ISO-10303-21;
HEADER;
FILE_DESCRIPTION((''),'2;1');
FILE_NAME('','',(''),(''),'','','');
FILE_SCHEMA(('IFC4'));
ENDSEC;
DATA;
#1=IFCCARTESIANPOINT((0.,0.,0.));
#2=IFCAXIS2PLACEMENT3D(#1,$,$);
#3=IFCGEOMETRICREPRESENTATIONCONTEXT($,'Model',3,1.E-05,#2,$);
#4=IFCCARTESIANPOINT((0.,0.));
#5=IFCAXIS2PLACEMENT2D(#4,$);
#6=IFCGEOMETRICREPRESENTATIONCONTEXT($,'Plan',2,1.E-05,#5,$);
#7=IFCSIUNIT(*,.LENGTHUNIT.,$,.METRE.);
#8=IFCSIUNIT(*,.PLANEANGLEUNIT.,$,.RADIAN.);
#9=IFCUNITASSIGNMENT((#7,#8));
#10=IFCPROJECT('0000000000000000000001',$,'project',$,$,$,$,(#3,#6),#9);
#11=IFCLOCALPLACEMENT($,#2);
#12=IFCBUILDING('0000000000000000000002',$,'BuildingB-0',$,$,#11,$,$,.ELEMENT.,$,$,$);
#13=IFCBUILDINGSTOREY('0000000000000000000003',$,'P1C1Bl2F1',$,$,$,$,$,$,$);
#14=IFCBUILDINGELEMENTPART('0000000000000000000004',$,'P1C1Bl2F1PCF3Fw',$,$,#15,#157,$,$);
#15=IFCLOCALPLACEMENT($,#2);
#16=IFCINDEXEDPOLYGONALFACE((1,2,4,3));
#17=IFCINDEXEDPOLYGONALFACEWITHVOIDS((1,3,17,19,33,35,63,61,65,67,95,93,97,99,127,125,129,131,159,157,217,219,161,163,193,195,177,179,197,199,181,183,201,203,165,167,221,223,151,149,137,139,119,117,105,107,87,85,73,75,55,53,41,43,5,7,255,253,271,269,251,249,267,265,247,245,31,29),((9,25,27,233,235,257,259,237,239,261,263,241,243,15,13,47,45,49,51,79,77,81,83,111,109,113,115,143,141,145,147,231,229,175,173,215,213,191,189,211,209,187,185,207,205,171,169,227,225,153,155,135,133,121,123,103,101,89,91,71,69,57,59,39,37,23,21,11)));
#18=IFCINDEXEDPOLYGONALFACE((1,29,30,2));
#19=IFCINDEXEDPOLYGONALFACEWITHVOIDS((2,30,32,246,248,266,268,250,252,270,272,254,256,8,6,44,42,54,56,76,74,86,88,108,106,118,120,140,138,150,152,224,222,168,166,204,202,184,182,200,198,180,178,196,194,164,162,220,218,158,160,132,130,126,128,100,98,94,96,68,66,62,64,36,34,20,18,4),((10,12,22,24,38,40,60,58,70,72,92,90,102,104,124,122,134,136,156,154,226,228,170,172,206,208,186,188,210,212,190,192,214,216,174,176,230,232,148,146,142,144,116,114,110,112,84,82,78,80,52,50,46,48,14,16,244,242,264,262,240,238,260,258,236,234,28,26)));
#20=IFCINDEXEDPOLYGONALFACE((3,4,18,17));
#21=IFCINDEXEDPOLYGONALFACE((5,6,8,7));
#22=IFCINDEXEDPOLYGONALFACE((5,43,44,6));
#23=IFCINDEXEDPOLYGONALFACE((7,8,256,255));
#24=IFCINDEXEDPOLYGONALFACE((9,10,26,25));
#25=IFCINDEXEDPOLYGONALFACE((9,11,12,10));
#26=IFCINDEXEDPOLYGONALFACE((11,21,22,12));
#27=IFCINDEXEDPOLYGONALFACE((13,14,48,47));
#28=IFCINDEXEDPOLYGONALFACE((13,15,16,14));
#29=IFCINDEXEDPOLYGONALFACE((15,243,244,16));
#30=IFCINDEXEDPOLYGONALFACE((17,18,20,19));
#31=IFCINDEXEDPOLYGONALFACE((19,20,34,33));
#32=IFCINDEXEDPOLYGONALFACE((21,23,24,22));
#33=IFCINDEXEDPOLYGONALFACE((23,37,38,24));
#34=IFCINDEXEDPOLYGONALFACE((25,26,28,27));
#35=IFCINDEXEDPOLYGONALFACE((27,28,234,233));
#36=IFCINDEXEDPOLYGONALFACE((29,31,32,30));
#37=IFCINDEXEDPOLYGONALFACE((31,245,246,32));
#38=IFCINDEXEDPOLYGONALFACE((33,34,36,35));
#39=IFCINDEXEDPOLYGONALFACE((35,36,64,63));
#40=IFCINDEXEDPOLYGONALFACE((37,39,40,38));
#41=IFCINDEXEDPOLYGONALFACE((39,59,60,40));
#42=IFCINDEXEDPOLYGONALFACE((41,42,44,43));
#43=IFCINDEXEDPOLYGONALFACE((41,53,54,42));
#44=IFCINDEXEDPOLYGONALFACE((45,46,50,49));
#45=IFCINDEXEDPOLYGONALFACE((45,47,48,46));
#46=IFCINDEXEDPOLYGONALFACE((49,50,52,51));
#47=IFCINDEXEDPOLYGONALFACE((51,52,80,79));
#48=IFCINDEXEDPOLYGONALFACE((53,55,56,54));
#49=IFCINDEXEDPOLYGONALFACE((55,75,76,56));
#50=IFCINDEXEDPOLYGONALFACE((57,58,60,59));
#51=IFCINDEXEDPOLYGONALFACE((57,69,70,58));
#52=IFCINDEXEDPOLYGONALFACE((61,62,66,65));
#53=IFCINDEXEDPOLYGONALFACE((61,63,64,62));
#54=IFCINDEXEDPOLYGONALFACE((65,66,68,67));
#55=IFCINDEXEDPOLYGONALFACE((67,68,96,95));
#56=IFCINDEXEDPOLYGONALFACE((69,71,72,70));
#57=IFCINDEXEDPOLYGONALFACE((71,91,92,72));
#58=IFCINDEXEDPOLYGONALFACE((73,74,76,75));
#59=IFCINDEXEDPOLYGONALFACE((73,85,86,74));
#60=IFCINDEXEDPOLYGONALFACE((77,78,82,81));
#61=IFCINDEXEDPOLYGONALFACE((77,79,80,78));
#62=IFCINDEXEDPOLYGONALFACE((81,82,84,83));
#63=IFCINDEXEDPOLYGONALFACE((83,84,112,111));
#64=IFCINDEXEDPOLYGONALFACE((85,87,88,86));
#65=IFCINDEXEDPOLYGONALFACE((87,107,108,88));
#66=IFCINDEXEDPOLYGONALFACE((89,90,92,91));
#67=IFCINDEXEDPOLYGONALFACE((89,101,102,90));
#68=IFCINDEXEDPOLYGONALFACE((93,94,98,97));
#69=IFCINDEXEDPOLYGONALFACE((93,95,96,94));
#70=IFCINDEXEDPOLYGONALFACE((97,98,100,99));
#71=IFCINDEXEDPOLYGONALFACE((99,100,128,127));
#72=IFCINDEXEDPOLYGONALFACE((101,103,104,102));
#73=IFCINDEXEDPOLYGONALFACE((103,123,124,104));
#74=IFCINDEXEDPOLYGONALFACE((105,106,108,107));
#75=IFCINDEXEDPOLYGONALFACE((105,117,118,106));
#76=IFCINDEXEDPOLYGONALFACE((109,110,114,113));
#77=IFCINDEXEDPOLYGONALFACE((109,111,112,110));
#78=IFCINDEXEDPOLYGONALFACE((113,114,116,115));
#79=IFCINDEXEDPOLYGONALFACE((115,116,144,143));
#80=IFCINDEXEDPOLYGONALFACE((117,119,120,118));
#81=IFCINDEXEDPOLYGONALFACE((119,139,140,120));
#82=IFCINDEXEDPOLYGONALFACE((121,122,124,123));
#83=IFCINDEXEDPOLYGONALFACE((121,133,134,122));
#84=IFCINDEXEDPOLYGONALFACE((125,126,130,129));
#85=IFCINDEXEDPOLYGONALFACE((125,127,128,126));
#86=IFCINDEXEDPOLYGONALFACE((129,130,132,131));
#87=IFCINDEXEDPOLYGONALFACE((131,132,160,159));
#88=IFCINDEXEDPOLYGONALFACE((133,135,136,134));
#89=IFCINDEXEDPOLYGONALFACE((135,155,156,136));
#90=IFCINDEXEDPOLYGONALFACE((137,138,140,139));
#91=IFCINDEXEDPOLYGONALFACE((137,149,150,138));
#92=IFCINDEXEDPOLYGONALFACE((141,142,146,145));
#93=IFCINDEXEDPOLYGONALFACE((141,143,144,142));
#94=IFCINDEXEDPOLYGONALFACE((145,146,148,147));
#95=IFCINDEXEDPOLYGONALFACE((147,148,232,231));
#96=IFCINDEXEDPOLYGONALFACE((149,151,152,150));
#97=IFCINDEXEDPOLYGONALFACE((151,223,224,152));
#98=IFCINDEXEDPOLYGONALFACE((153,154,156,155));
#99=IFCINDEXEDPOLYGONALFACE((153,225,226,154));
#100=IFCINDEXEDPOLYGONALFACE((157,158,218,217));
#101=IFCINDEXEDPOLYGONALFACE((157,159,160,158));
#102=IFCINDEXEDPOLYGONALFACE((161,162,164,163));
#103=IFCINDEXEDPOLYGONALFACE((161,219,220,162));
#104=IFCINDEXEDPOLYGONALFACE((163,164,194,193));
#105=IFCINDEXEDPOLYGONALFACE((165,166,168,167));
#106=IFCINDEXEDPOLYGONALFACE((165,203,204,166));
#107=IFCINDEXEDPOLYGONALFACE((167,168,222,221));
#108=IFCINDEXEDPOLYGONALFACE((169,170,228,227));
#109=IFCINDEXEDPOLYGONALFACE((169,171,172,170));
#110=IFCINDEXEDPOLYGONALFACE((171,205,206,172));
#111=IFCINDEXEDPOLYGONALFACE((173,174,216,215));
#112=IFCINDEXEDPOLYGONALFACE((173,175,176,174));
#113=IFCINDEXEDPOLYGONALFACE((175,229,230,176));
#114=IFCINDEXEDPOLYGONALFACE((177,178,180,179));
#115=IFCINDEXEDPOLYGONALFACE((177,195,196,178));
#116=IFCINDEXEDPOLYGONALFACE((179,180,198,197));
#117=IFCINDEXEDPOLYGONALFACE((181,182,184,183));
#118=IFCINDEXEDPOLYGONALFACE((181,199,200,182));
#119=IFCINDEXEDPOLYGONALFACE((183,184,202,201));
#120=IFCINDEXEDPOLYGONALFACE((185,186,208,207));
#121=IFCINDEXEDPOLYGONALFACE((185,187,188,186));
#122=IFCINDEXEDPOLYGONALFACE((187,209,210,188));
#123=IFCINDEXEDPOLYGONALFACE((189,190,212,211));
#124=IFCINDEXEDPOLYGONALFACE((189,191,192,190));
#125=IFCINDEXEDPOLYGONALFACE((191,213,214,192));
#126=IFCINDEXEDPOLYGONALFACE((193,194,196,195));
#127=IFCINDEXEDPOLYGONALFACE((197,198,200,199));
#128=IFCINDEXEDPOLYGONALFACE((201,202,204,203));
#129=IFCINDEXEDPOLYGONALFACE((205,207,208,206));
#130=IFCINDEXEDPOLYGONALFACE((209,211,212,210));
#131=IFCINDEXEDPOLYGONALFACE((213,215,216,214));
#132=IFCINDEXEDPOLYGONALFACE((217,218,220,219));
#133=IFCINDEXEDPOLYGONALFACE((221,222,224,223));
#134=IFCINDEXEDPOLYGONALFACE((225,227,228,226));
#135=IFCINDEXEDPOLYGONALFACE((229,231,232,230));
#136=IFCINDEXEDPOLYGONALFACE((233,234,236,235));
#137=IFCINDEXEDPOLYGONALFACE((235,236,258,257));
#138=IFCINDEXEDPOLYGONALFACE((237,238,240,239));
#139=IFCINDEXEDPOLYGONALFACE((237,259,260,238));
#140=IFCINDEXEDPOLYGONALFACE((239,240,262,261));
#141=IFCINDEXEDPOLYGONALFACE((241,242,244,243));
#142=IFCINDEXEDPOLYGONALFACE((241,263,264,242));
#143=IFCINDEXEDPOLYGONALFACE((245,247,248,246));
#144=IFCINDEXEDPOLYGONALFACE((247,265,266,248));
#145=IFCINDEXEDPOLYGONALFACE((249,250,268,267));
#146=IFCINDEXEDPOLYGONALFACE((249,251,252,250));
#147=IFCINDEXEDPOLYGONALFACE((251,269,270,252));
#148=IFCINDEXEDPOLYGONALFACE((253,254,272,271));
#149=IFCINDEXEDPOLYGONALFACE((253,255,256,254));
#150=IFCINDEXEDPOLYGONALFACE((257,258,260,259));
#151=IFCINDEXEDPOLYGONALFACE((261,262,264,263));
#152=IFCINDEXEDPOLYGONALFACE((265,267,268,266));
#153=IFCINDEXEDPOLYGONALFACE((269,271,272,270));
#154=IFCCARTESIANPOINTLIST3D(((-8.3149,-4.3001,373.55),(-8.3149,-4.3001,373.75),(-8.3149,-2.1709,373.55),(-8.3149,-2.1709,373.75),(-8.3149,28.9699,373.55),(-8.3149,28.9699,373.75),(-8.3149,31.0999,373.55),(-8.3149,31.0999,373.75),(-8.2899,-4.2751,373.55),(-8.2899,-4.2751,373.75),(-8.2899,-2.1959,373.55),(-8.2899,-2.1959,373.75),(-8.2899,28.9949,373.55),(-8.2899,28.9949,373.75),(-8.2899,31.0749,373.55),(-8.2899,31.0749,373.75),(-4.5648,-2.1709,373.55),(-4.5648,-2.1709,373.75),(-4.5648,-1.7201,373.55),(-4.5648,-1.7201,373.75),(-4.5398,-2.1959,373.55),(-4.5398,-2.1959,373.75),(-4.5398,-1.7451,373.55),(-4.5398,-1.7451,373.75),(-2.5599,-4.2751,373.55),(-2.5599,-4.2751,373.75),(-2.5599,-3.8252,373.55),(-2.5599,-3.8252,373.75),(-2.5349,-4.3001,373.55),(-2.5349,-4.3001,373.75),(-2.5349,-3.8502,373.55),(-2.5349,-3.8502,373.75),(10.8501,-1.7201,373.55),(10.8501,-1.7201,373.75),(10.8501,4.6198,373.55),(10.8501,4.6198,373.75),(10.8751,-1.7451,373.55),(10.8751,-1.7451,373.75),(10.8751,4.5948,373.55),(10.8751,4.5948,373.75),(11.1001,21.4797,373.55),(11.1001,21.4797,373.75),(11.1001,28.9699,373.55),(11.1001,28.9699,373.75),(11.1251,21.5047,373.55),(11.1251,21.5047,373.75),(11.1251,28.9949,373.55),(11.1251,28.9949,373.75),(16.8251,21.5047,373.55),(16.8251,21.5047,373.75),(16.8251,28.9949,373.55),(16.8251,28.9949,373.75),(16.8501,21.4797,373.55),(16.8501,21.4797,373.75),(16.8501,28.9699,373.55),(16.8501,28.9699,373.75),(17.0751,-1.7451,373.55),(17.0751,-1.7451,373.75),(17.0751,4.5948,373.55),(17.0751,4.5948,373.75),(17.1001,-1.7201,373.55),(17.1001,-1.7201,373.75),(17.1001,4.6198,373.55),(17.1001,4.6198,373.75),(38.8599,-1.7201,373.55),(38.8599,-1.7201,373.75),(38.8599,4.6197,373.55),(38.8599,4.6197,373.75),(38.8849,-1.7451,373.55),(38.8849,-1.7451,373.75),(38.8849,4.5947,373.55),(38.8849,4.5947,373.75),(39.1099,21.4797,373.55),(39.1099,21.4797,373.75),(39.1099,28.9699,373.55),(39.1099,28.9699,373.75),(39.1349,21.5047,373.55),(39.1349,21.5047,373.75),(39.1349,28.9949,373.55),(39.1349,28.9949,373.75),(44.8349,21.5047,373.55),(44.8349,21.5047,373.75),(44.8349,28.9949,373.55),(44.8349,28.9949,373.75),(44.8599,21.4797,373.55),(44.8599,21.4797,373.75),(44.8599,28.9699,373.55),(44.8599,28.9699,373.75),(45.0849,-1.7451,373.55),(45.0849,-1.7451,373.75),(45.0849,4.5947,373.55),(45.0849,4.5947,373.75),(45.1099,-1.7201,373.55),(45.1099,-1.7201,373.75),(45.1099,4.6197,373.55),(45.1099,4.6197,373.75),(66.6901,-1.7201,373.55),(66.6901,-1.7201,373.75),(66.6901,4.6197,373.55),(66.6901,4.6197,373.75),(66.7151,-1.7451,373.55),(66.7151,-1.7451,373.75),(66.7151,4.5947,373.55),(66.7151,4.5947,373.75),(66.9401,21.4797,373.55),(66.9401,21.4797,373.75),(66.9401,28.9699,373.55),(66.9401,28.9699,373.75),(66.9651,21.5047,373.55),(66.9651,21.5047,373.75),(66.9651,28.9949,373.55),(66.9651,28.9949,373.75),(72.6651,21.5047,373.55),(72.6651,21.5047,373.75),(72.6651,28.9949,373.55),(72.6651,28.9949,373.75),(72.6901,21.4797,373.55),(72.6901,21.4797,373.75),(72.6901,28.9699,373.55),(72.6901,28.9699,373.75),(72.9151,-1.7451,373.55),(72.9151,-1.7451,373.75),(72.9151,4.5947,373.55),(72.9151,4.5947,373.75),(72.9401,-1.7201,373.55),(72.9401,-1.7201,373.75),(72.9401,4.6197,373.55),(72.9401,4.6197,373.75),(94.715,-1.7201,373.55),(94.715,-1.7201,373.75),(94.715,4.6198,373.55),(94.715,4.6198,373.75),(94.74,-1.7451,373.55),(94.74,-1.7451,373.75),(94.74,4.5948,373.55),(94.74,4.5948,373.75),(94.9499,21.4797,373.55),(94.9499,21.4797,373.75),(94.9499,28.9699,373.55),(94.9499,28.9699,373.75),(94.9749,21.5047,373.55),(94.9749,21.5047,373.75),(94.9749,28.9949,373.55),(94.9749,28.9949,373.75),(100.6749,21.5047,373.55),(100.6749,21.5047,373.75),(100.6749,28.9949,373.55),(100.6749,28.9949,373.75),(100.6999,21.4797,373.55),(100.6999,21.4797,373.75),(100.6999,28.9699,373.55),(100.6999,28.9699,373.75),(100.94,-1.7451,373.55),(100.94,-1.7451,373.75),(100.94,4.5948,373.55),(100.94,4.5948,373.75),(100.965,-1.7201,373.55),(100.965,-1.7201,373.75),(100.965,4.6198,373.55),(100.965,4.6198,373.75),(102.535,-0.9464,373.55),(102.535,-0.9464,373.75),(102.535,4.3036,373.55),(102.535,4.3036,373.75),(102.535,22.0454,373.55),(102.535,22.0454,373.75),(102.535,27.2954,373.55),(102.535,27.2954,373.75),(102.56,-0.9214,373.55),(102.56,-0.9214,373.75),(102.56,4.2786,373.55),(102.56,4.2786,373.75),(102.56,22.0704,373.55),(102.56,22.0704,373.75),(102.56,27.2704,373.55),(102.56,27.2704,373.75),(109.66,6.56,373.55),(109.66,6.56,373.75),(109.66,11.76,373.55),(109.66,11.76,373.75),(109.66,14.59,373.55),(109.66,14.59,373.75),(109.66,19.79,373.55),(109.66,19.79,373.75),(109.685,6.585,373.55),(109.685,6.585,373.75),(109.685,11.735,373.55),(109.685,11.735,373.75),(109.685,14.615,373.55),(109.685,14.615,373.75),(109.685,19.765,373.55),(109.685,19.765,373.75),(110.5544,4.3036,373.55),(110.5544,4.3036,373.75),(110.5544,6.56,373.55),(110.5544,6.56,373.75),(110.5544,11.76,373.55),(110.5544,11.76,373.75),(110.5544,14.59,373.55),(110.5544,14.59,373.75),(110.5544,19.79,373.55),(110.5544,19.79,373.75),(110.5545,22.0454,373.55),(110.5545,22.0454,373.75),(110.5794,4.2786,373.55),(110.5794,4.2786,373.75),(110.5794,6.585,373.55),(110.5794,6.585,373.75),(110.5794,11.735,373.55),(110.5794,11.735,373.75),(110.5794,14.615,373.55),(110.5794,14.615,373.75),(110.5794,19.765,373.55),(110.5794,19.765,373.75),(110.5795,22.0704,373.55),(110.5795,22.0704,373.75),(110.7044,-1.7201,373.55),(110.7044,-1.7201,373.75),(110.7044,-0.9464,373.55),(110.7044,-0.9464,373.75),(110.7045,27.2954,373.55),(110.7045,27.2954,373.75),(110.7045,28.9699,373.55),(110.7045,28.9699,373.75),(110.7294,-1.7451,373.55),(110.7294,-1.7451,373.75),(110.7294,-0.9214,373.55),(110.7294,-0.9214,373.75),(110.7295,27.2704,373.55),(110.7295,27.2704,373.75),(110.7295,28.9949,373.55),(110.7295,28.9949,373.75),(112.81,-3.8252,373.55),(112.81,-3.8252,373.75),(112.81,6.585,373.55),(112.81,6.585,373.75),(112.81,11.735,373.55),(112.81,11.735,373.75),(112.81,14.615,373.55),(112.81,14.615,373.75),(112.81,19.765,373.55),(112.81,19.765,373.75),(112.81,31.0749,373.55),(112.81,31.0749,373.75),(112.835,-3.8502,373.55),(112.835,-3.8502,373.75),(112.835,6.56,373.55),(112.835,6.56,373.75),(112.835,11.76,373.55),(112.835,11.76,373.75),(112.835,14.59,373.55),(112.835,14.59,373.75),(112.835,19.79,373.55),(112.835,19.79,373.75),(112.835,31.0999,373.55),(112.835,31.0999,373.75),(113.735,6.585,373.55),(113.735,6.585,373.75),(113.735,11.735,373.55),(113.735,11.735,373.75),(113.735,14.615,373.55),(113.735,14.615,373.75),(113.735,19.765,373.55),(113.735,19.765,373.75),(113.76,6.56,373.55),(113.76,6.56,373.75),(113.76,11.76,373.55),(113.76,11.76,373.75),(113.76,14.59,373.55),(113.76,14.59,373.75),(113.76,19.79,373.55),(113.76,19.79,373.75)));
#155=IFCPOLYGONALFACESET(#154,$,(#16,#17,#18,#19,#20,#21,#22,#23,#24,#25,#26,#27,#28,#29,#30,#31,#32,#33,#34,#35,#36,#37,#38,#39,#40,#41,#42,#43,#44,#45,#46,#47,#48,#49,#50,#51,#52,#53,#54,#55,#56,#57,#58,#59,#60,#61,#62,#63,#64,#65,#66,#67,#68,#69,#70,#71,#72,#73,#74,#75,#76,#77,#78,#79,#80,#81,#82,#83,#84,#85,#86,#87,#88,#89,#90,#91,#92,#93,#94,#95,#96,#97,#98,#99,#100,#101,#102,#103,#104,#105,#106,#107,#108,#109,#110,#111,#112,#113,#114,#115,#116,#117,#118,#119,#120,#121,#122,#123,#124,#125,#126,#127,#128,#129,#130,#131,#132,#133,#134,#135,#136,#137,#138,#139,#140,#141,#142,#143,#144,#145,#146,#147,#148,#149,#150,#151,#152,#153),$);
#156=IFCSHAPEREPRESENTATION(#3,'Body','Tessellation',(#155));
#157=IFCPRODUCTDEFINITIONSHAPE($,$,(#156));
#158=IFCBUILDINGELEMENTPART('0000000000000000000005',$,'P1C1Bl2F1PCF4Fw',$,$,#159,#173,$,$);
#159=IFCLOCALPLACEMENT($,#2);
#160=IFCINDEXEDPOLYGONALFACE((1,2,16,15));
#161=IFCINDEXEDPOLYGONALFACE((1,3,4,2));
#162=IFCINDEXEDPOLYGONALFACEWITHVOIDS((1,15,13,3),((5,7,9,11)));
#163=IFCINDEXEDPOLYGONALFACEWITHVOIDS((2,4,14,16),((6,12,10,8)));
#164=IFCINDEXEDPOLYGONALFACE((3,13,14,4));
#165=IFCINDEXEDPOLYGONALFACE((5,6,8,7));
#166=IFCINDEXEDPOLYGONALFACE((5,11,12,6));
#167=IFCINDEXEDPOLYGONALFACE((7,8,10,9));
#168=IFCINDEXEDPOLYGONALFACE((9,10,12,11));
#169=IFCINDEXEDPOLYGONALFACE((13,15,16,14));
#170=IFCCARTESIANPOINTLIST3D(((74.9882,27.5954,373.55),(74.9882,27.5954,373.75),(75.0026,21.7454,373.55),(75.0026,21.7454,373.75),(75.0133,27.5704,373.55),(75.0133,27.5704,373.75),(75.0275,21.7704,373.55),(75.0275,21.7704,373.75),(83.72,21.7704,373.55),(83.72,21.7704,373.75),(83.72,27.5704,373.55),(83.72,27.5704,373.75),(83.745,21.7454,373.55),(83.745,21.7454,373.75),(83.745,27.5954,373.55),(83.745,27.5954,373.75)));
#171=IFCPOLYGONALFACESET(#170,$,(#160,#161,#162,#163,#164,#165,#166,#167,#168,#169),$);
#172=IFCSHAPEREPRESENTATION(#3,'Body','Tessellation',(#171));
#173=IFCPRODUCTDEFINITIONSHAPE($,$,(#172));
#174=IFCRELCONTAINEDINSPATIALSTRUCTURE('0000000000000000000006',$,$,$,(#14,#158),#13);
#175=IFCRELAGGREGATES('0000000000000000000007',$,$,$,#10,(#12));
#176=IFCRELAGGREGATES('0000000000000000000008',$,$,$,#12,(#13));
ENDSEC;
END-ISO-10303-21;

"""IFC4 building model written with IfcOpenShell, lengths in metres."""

from ifc_helpers import new_model, si_unit, origin, origin_2d, place, context, project, spatial, polyline, outline, extrude, element, save


model = new_model("IFC4")

# Units and contexts
model_context = context("Model", 3, precision=1e-05, world=origin())
plan_context = context("Plan", 2, precision=1e-05, world=origin_2d())
ifc_project = project(units=[si_unit("LENGTHUNIT", "METRE"), si_unit("PLANEANGLEUNIT", "RADIAN")], contexts=[model_context, plan_context])

# Building, storey
building_placement = place(None, origin())
building = spatial("IfcBuilding", under=ifc_project, at=building_placement, Name="BuildingB-0", CompositionType="ELEMENT")
storey = spatial("IfcBuildingStorey", under=building, Name="P1C1Bl2F1")

# Building element parts, openings
building_element_part_1 = element("IfcBuildingElementPart", 1, inside=storey, Name="P1C1Bl2F1PCF3Fw", context=model_context, shape_type="SweptSolid", body=[
    extrude(outline(polyline([(-8.3149, 31.0999, 373.55), (-8.3149, 28.9699, 373.55), (11.1001, 28.9699, 373.55), (11.1001, 21.4797, 373.55), (16.8501, 21.4797, 373.55), (16.8501, 28.9699, 373.55), (39.1099, 28.9699, 373.55), (39.1099, 21.4797, 373.55), (44.8599, 21.4797, 373.55), (44.8599, 28.9699, 373.55), (66.9401, 28.9699, 373.55), (66.9401, 21.4797, 373.55), (72.6901, 21.4797, 373.55), (72.6901, 28.9699, 373.55), (94.9499, 28.9699, 373.55), (94.9499, 21.4797, 373.55), (100.6999, 21.4797, 373.55), (100.6999, 28.9699, 373.55), (110.7045, 28.9699, 373.55), (110.7045, 27.2954, 373.55), (102.535, 27.2954, 373.55), (102.535, 22.0454, 373.55), (110.5545, 22.0454, 373.55), (110.5544, 19.79, 373.55), (109.66, 19.79, 373.55), (109.66, 14.59, 373.55), (110.5544, 14.59, 373.55), (110.5544, 11.76, 373.55), (109.66, 11.76, 373.55), (109.66, 6.56, 373.55), (110.5544, 6.56, 373.55), (110.5544, 4.3036, 373.55), (102.535, 4.3036, 373.55), (102.535, -0.9464, 373.55), (110.7044, -0.9464, 373.55), (110.7044, -1.7201, 373.55), (100.965, -1.7201, 373.55), (100.965, 4.6198, 373.55), (94.715, 4.6198, 373.55), (94.715, -1.7201, 373.55), (72.9401, -1.7201, 373.55), (72.9401, 4.6197, 373.55), (66.6901, 4.6197, 373.55), (66.6901, -1.7201, 373.55), (45.1099, -1.7201, 373.55), (45.1099, 4.6197, 373.55), (38.8599, 4.6197, 373.55), (38.8599, -1.7201, 373.55), (17.1001, -1.7201, 373.55), (17.1001, 4.6198, 373.55), (10.8501, 4.6198, 373.55), (10.8501, -1.7201, 373.55), (-4.5648, -1.7201, 373.55), (-4.5648, -2.1709, 373.55), (-8.3149, -2.1709, 373.55), (-8.3149, -4.3001, 373.55), (-2.5349, -4.3001, 373.55), (-2.5349, -3.8502, 373.55), (112.835, -3.8502, 373.55), (112.835, 6.56, 373.55), (113.76, 6.56, 373.55), (113.76, 11.76, 373.55), (112.835, 11.76, 373.55), (112.835, 14.59, 373.55), (113.76, 14.59, 373.55), (113.76, 19.79, 373.55), (112.835, 19.79, 373.55), (112.835, 31.0999, 373.55), (-8.3149, 31.0999, 373.55)])), None, (0.0, 0.0, 1.0), 0.2),
])
element("IfcOpeningElement", 2, inside=storey, cuts=building_element_part_1, context=model_context, shape_type="SweptSolid", body=[
    extrude(outline(polyline([(-8.2899, 31.0749, 373.55), (-8.2899, 28.9949, 373.55), (11.1251, 28.9949, 373.55), (11.1251, 21.5047, 373.55), (16.8251, 21.5047, 373.55), (16.8251, 28.9949, 373.55), (39.1349, 28.9949, 373.55), (39.1349, 21.5047, 373.55), (44.8349, 21.5047, 373.55), (44.8349, 28.9949, 373.55), (66.9651, 28.9949, 373.55), (66.9651, 21.5047, 373.55), (72.6651, 21.5047, 373.55), (72.6651, 28.9949, 373.55), (94.9749, 28.9949, 373.55), (94.9749, 21.5047, 373.55), (100.6749, 21.5047, 373.55), (100.6749, 28.9949, 373.55), (110.7295, 28.9949, 373.55), (110.7295, 27.2704, 373.55), (102.56, 27.2704, 373.55), (102.56, 22.0704, 373.55), (110.5795, 22.0704, 373.55), (110.5794, 19.765, 373.55), (109.685, 19.765, 373.55), (109.685, 14.615, 373.55), (110.5794, 14.615, 373.55), (110.5794, 11.735, 373.55), (109.685, 11.735, 373.55), (109.685, 6.585, 373.55), (110.5794, 6.585, 373.55), (110.5794, 4.2786, 373.55), (102.56, 4.2786, 373.55), (102.56, -0.9214, 373.55), (110.7294, -0.9214, 373.55), (110.7294, -1.7451, 373.55), (100.94, -1.7451, 373.55), (100.94, 4.5948, 373.55), (94.74, 4.5948, 373.55), (94.74, -1.7451, 373.55), (72.9151, -1.7451, 373.55), (72.9151, 4.5947, 373.55), (66.7151, 4.5947, 373.55), (66.7151, -1.7451, 373.55), (45.0849, -1.7451, 373.55), (45.0849, 4.5947, 373.55), (38.8849, 4.5947, 373.55), (38.8849, -1.7451, 373.55), (17.0751, -1.7451, 373.55), (17.0751, 4.5948, 373.55), (10.8751, 4.5948, 373.55), (10.8751, -1.7451, 373.55), (-4.5398, -1.7451, 373.55), (-4.5398, -2.1959, 373.55), (-8.2899, -2.1959, 373.55), (-8.2899, -4.2751, 373.55), (-2.5599, -4.2751, 373.55), (-2.5599, -3.8252, 373.55), (112.81, -3.8252, 373.55), (112.81, 6.585, 373.55), (113.735, 6.585, 373.55), (113.735, 11.735, 373.55), (112.81, 11.735, 373.55), (112.81, 14.615, 373.55), (113.735, 14.615, 373.55), (113.735, 19.765, 373.55), (112.81, 19.765, 373.55), (112.81, 31.0749, 373.55), (-8.2899, 31.0749, 373.55)])), None, (0.0, 0.0, 1.0), 0.2),
])
building_element_part_2 = element("IfcBuildingElementPart", 3, inside=storey, Name="P1C1Bl2F1PCF4Fw", context=model_context, shape_type="SweptSolid", body=[
    extrude(outline(polyline([(75.0026, 21.7454, 373.55), (83.745, 21.7454, 373.55), (83.745, 27.5954, 373.55), (74.9882, 27.5954, 373.55), (75.0026, 21.7454, 373.55)])), None, (0.0, 0.0, 1.0), 0.2),
])
element("IfcOpeningElement", 4, inside=storey, cuts=building_element_part_2, context=model_context, shape_type="SweptSolid", body=[
    extrude(outline(polyline([(75.0275, 21.7704, 373.55), (83.72, 21.7704, 373.55), (83.72, 27.5704, 373.55), (75.0133, 27.5704, 373.55), (75.0275, 21.7704, 373.55)])), None, (0.0, 0.0, 1.0), 0.2),
])

save(model, "model.ifc")
